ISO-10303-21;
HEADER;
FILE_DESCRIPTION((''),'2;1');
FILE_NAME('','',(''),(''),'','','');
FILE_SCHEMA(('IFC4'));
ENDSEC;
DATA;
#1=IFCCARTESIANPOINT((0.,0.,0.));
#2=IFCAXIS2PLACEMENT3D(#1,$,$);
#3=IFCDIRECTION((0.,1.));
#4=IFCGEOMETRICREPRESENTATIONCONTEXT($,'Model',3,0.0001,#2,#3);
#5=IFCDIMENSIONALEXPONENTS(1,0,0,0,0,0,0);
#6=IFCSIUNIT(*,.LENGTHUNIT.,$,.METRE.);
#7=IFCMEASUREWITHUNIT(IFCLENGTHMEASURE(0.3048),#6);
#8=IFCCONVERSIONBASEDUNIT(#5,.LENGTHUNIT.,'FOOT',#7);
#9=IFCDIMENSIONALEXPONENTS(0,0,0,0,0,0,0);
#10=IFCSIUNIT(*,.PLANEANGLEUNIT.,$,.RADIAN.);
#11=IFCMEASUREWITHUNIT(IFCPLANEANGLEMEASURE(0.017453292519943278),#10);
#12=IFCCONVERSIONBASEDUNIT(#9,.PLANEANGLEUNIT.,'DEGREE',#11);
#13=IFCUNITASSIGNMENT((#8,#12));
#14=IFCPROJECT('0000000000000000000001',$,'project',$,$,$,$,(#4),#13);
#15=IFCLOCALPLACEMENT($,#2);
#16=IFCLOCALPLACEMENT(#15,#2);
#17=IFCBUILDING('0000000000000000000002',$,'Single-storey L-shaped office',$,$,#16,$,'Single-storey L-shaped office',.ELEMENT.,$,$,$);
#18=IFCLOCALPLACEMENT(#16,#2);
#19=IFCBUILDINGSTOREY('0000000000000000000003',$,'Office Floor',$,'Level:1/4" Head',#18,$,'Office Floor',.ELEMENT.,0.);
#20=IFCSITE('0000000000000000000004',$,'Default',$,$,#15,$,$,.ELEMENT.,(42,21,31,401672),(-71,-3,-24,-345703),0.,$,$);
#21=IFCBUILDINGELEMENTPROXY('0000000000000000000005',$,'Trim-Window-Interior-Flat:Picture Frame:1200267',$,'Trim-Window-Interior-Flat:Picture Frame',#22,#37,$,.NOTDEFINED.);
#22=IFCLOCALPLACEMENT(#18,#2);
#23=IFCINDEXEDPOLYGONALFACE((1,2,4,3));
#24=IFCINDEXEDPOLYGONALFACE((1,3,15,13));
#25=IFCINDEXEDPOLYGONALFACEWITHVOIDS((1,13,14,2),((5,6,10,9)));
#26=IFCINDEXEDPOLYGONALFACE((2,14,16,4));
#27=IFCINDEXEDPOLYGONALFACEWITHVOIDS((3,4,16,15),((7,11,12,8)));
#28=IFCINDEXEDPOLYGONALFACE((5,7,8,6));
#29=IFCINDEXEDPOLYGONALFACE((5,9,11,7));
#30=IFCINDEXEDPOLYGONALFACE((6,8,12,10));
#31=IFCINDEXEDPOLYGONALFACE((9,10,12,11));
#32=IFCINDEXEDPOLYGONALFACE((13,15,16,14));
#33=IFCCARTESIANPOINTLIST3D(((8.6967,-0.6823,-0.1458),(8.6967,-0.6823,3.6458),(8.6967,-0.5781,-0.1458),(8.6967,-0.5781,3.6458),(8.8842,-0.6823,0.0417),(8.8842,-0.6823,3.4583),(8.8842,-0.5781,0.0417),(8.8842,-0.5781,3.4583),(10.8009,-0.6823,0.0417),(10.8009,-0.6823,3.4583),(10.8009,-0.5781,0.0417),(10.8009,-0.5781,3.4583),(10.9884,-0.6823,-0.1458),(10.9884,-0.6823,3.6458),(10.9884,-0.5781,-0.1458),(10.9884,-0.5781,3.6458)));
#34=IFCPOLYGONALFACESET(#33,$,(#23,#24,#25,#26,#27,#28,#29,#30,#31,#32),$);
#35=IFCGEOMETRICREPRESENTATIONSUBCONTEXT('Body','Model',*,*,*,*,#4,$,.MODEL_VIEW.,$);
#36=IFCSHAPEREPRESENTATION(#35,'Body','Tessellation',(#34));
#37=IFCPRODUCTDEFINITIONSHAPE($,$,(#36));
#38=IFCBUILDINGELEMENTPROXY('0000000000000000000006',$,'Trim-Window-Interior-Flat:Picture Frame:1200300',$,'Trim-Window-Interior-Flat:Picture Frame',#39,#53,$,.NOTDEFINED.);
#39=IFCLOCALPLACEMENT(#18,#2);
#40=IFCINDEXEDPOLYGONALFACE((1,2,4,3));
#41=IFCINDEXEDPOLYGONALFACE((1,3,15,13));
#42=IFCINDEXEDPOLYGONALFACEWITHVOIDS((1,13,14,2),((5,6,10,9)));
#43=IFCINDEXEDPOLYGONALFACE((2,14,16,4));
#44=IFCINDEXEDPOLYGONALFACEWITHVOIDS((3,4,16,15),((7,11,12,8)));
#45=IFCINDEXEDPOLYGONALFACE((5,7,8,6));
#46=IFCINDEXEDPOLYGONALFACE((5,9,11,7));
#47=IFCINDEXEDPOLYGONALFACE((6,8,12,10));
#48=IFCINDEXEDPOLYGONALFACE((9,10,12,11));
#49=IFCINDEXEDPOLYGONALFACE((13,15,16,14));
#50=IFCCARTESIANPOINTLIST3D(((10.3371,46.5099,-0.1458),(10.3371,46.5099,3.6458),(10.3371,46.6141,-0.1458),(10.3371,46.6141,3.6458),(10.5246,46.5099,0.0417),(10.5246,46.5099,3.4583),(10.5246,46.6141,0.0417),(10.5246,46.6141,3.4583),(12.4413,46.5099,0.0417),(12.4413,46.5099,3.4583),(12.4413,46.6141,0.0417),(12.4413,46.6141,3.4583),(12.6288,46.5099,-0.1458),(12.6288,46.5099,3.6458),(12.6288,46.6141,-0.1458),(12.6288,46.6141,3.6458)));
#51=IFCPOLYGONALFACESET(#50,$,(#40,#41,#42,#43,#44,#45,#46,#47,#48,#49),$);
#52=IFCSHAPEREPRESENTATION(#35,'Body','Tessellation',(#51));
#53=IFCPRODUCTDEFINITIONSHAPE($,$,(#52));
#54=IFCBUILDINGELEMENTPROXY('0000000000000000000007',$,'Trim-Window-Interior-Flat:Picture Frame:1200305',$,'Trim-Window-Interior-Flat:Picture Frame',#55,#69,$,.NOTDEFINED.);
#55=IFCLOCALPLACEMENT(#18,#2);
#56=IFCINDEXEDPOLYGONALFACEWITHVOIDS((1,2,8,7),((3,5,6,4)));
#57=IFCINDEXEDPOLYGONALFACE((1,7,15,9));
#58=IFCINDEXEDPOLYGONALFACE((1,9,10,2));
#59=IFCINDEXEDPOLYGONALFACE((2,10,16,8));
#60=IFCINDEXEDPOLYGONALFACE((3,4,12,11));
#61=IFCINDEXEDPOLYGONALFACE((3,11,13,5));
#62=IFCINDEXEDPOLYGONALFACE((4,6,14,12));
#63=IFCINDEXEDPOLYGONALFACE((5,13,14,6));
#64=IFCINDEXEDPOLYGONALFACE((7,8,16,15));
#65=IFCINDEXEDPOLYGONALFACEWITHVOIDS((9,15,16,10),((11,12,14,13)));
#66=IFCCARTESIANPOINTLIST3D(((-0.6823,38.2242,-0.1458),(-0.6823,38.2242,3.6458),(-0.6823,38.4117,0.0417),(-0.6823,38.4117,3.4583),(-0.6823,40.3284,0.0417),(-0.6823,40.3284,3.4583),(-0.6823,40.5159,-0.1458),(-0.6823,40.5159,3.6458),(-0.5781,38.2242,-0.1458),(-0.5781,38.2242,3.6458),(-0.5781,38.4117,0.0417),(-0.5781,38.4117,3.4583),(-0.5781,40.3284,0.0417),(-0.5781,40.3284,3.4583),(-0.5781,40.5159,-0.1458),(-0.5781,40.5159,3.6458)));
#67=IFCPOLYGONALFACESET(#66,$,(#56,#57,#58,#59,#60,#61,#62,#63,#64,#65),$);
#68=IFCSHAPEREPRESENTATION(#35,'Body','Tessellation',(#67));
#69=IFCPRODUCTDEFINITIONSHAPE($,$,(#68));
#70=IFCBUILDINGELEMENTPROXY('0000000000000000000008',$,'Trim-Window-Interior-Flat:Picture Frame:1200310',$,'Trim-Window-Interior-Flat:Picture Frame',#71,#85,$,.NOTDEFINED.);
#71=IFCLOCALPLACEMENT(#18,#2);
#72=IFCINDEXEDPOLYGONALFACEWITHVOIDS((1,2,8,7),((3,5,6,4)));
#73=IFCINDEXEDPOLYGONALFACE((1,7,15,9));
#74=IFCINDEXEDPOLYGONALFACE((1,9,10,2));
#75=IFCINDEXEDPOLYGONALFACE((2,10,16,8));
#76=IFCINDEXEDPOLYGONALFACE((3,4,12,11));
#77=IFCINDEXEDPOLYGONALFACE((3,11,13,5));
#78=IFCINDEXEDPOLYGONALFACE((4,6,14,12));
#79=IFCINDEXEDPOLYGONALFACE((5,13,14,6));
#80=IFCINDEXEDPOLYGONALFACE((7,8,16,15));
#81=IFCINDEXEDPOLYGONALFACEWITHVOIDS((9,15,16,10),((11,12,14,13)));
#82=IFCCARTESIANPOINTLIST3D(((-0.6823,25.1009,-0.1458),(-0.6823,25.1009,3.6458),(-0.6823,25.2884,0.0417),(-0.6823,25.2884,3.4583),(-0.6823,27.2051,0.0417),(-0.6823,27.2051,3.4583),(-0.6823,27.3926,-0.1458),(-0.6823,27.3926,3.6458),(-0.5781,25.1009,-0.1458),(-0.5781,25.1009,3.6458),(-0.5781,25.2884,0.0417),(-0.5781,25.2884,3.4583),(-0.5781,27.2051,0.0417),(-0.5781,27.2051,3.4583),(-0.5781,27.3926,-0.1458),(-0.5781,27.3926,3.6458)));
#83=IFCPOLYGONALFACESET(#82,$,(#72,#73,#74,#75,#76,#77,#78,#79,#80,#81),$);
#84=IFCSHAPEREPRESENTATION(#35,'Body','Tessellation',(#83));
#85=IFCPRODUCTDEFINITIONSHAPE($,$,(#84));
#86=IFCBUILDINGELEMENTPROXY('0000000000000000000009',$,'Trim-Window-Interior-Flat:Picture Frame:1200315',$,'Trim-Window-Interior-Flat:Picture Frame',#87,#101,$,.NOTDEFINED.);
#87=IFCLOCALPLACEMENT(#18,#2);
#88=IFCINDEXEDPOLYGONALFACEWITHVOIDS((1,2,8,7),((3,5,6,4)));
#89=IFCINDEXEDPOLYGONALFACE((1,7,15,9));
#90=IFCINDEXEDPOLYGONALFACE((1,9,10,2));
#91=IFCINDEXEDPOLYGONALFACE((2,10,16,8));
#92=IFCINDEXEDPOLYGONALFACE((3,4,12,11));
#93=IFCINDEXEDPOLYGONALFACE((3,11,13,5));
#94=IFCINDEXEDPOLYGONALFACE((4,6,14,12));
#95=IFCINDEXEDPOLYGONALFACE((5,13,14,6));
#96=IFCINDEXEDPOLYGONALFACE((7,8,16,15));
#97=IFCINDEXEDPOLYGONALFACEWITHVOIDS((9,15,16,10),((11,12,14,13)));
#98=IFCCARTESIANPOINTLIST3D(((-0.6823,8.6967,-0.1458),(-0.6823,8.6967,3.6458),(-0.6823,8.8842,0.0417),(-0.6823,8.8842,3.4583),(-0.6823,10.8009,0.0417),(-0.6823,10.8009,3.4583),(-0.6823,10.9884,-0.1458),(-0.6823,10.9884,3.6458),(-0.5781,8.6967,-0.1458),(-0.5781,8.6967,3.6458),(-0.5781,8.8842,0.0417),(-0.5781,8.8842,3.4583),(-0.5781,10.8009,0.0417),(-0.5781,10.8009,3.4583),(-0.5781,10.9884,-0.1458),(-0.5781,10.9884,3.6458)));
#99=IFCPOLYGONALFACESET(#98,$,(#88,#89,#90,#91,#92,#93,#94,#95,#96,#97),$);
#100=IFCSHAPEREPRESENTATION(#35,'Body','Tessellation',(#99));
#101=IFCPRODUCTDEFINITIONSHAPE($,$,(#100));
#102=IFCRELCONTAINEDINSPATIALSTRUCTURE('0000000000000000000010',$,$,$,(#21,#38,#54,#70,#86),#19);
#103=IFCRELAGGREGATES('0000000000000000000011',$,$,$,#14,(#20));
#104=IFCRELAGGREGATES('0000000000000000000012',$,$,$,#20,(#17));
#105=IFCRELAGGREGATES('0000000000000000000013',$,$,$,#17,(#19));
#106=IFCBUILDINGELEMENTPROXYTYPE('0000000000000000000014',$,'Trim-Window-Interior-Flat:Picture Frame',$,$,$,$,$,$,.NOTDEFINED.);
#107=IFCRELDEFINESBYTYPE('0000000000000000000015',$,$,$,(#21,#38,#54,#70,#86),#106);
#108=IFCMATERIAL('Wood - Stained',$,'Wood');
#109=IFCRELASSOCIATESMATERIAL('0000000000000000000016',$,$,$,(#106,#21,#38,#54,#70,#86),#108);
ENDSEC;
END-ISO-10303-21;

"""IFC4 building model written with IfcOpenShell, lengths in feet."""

from ifc_helpers import new_model, entity, si_unit, converted_unit, direction, frame, origin, place, context, subcontext, project, spatial, indexed_curve, outline, extrude, source, transform, mapped, material, type_object, type_shapes, element, save


model = new_model("IFC4")

# Units and contexts
model_context = context("Model", 3, precision=0.0001, world=origin(), true_north=direction((0.0, 1.0)))
body_context = subcontext(model_context, "Body", "Model", "MODEL_VIEW")
ifc_project = project(units=[converted_unit("LENGTHUNIT", "FOOT", entity("IfcLengthMeasure", 0.3048), si_unit("LENGTHUNIT", "METRE"), dimensions=[1, 0, 0, 0, 0, 0, 0]), converted_unit("PLANEANGLEUNIT", "DEGREE", entity("IfcPlaneAngleMeasure", 0.017453292519943278), si_unit("PLANEANGLEUNIT", "RADIAN"), dimensions=[0, 0, 0, 0, 0, 0, 0])], contexts=[model_context])

# Site, building, storey
site_placement = place(None, origin())
site = spatial("IfcSite", under=ifc_project, at=site_placement, Name="Default", CompositionType="ELEMENT", RefLatitude=(42, 21, 31, 401672), RefLongitude=(-71, -3, -24, -345703), RefElevation=0.0)
building_placement = place(site_placement, origin())
building = spatial("IfcBuilding", under=site, at=building_placement, Name="Single-storey L-shaped office", LongName="Single-storey L-shaped office", CompositionType="ELEMENT")
storey_placement = place(building_placement, origin())
storey = spatial("IfcBuildingStorey", under=building, at=storey_placement, Name="Office Floor", ObjectType="Level:1/4\" Head", LongName="Office Floor", CompositionType="ELEMENT", Elevation=0.0)

# Shared definitions
ifc_material_1 = material(Name="Wood - Stained", Category="Wood")

# Building element proxies
building_element_proxy_type_1 = type_object("IfcBuildingElementProxyType", Name="Trim-Window-Interior-Flat:Picture Frame", PredefinedType="NOTDEFINED", material=ifc_material_1)
shared_shape_1 = source(origin(), body_context, "Body", "SweptSolid", [
    extrude(outline(indexed_curve([(-1.1458, -1.8958), (1.1458, -1.8958), (1.1458, 1.8958), (-1.1458, 1.8958), (-1.1458, -1.8958)], self_intersect=False), holes=[indexed_curve([(-0.9583, -1.7083), (-0.9583, 1.7083), (0.9583, 1.7083), (0.9583, -1.7083), (-0.9583, -1.7083)], self_intersect=False)]), frame((0.0, -1.75, 0.0), z_axis=(0.0, 0.0, 1.0), x_axis=(-1.0, 0.0, 0.0)), (0.0, 0.0, 1.0), 0.1042),
])
type_shapes(building_element_proxy_type_1, [shared_shape_1])
for number, where, z_axis, x_axis, name in (
    (1, (9.8425, -0.5781, 3.5), (0.0, -1.0, 0.0), (1.0, 0.0, 0.0), "Trim-Window-Interior-Flat:Picture Frame:1200267"),
    (2, (11.4829, 46.5099, 3.5), (0.0, 1.0, 0.0), (-1.0, 0.0, 0.0), "Trim-Window-Interior-Flat:Picture Frame:1200300"),
    (3, (-0.5781, 39.3701, 3.5), (-1.0, 0.0, 0.0), (0.0, -1.0, 0.0), "Trim-Window-Interior-Flat:Picture Frame:1200305"),
    (4, (-0.5781, 26.2467, 3.5), (-1.0, 0.0, 0.0), (0.0, -1.0, 0.0), "Trim-Window-Interior-Flat:Picture Frame:1200310"),
    (5, (-0.5781, 9.8425, 3.5), (-1.0, 0.0, 0.0), (0.0, -1.0, 0.0), "Trim-Window-Interior-Flat:Picture Frame:1200315"),
):
    element("IfcBuildingElementProxy", number, at=place(storey_placement, frame(where, z_axis=z_axis, x_axis=x_axis)), inside=storey, type_object=building_element_proxy_type_1, material=ifc_material_1, Name=name, ObjectType="Trim-Window-Interior-Flat:Picture Frame", PredefinedType="NOTDEFINED", context=body_context, shape_type="MappedRepresentation", body=[
        mapped(shared_shape_1, transform((0.0, 0.0, 0.0), scale=1.0)),
    ])

save(model, "model.ifc")
